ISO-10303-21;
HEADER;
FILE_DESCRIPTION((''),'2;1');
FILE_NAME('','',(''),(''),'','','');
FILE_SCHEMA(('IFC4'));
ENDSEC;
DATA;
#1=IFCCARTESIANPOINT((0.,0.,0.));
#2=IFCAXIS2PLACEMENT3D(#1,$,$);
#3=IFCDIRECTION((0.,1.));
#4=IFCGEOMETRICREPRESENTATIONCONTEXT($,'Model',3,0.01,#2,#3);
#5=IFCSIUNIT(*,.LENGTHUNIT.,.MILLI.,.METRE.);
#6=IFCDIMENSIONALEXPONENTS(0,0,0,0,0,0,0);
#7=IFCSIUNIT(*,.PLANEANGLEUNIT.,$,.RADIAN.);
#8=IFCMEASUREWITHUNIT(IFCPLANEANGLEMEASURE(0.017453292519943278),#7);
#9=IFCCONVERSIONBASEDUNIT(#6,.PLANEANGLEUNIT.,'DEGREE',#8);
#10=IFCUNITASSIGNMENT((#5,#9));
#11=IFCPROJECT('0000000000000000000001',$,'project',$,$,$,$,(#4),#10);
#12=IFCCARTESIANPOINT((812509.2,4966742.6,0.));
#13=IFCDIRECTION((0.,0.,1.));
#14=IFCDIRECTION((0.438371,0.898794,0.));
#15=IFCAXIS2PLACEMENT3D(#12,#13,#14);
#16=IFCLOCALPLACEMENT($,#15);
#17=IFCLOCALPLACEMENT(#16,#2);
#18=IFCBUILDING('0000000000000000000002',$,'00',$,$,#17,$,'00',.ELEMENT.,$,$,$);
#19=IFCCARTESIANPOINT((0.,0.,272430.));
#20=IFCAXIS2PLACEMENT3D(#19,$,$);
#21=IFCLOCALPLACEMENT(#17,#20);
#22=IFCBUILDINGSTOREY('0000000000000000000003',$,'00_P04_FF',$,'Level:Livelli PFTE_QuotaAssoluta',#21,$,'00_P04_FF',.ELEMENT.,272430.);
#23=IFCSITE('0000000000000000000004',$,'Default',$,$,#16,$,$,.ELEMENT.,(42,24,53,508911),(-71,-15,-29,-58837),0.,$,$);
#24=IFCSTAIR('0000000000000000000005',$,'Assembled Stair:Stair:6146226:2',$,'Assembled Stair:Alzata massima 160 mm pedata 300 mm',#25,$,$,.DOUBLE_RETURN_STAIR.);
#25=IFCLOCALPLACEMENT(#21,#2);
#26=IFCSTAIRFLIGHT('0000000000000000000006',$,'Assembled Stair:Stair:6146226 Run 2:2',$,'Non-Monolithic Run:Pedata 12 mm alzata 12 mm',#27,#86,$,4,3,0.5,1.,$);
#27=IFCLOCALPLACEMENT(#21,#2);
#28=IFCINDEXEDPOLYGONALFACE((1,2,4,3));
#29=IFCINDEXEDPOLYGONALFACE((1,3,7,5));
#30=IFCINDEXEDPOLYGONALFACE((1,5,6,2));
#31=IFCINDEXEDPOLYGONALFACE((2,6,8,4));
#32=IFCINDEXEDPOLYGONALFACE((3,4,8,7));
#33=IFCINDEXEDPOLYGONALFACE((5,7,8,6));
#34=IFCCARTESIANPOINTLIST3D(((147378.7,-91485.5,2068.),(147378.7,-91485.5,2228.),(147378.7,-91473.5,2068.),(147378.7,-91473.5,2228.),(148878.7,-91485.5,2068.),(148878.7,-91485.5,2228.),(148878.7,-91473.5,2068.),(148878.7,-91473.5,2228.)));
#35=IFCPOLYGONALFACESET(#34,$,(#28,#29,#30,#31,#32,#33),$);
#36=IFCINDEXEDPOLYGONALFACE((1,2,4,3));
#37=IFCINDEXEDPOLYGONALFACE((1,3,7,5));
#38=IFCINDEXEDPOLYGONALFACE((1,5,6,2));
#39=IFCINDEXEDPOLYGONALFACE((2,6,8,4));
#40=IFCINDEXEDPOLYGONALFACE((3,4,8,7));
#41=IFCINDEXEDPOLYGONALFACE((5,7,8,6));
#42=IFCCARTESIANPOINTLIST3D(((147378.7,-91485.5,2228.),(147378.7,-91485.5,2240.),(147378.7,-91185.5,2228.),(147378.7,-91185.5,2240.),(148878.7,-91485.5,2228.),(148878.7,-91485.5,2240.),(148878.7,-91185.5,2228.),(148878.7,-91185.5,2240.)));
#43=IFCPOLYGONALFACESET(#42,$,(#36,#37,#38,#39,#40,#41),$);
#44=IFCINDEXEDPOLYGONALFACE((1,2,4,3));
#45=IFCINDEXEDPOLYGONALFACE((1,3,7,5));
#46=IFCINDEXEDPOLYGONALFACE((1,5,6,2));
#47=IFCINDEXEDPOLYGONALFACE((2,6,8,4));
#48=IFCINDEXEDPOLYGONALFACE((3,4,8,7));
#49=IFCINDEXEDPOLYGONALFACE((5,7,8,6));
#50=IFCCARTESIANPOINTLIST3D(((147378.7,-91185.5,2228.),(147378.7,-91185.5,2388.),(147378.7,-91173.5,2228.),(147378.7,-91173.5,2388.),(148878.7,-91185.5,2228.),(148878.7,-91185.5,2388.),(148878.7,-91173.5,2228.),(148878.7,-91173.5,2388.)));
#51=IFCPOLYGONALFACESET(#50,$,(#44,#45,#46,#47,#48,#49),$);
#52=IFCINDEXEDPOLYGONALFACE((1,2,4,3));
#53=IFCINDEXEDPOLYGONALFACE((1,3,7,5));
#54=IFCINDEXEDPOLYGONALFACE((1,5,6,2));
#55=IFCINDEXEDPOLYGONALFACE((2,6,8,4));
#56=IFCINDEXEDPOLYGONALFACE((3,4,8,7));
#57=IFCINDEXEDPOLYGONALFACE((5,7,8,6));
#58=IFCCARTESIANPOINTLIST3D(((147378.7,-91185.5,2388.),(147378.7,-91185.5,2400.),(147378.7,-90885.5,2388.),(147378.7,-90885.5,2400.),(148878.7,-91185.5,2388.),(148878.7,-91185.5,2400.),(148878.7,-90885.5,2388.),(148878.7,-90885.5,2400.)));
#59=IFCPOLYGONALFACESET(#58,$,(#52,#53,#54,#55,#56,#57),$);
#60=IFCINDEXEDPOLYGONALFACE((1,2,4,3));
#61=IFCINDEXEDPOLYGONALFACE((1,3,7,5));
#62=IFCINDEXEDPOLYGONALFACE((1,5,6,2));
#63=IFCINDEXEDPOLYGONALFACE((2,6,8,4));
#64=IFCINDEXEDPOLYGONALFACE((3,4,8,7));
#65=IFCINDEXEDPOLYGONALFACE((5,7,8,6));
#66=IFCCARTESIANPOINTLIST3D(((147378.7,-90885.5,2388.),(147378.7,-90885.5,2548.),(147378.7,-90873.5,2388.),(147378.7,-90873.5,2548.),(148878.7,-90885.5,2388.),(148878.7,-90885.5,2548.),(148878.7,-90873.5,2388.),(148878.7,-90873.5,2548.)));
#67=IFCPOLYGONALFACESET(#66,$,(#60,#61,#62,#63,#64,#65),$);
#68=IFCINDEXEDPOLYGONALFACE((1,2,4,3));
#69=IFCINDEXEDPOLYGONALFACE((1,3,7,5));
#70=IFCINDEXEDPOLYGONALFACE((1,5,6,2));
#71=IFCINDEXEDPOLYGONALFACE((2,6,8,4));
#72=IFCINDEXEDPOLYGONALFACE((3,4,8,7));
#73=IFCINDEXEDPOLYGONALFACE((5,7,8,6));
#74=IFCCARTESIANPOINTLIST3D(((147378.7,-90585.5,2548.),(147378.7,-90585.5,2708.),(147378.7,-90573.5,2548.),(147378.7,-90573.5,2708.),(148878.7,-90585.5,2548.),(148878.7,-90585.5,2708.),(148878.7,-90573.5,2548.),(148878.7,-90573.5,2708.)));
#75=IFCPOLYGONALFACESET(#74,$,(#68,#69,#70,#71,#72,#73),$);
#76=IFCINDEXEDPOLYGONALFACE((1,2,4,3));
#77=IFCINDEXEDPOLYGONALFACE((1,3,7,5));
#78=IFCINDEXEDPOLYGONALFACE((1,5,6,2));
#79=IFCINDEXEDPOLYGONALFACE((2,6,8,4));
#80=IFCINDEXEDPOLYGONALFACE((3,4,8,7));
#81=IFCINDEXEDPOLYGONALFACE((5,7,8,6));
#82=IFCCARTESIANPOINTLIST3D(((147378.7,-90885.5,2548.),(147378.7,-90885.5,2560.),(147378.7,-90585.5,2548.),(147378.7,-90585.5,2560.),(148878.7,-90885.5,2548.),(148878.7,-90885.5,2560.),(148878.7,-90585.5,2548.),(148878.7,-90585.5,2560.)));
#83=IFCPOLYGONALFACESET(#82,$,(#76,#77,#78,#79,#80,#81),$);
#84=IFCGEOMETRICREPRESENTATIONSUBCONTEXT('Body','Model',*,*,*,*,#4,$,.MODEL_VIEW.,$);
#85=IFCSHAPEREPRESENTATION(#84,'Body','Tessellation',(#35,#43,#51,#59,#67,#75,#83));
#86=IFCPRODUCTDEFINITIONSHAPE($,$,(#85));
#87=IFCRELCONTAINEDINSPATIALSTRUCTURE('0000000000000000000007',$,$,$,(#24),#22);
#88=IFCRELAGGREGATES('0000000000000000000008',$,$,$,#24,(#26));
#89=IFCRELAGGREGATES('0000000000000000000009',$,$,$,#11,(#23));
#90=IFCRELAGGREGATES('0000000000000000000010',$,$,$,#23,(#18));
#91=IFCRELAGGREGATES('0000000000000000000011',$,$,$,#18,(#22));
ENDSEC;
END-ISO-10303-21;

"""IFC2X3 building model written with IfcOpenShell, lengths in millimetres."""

from ifc_helpers import new_model, entity, si_unit, converted_unit, direction, frame, frame_2d, origin, origin_2d_with_axis, place, context, subcontext, project, spatial, rectangle, extrude, element, aggregate, save


model = new_model("IFC2X3")

# Units and contexts
model_context = context("Model", 3, precision=0.01, world=origin(), true_north=direction((0.0, 1.0)))
body_context = subcontext(model_context, "Body", "Model", "MODEL_VIEW")
ifc_project = project(units=[si_unit("LENGTHUNIT", "METRE", prefix="MILLI"), converted_unit("PLANEANGLEUNIT", "DEGREE", entity("IfcPlaneAngleMeasure", 0.017453292519943278), si_unit("PLANEANGLEUNIT", "RADIAN"), dimensions=[0, 0, 0, 0, 0, 0, 0])], contexts=[model_context])

# Site, building, storey
site_placement = place(None, frame((812509.2, 4966742.6, 0.0), z_axis=(0.0, 0.0, 1.0), x_axis=(0.438371, 0.898794, 0.0)))
site = spatial("IfcSite", under=ifc_project, at=site_placement, Name="Default", CompositionType="ELEMENT", RefLatitude=(42, 24, 53, 508911), RefLongitude=(-71, -15, -29, -58837), RefElevation=0.0)
building_placement = place(site_placement, origin())
building = spatial("IfcBuilding", under=site, at=building_placement, Name="00", LongName="00", CompositionType="ELEMENT")
storey_placement = place(building_placement, frame((0.0, 0.0, 272430.0)))
storey = spatial("IfcBuildingStorey", under=building, at=storey_placement, Name="00_P04_FF", ObjectType="Level:Livelli PFTE_QuotaAssoluta", LongName="00_P04_FF", CompositionType="ELEMENT", Elevation=272430.0)

# Stair
stair_1_placement = place(storey_placement, origin())
stair_1 = element("IfcStair", 1, at=stair_1_placement, inside=storey, Name="Assembled Stair:Stair:6146226:2", ObjectType="Assembled Stair:Alzata massima 160 mm pedata 300 mm", ShapeType="DOUBLE_RETURN_STAIR")

# Stair flight
stair_flight_1_placement = place(stair_1_placement, origin())
stair_flight_1 = element("IfcStairFlight", 2, at=stair_flight_1_placement, Name="Assembled Stair:Stair:6146226 Run 2:2", ObjectType="Non-Monolithic Run:Pedata 12 mm alzata 12 mm", NumberOfRiser=4, NumberOfTreads=3, RiserHeight=0.5, TreadLength=1.0, context=body_context, shape_type="SweptSolid", body=[
    extrude(rectangle(XDim=1500.0, YDim=12.0, at=origin_2d_with_axis()), frame((148128.7, -91479.5, 2068.0), z_axis=(0.0, 0.0, 1.0), x_axis=(-1.0, 0.0, 0.0)), (0.0, 0.0, 1.0), 160.0),
    extrude(rectangle(XDim=300.0, YDim=1500.0, at=frame_2d((0.0, 0.0), x_axis=(1.0, 0.0))), frame((148128.7, -91335.5, 2228.0), z_axis=(0.0, 0.0, 1.0), x_axis=(0.0, -1.0, 0.0)), (0.0, 0.0, 1.0), 12.0),
    extrude(rectangle(XDim=1500.0, YDim=12.0, at=frame_2d((0.0, 0.0), x_axis=(1.0, 0.0))), frame((148128.7, -91179.5, 2228.0), z_axis=(0.0, 0.0, 1.0), x_axis=(-1.0, 0.0, 0.0)), (0.0, 0.0, 1.0), 160.0),
    extrude(rectangle(XDim=300.0, YDim=1500.0, at=origin_2d_with_axis()), frame((148128.7, -91035.5, 2388.0), z_axis=(0.0, 0.0, 1.0), x_axis=(0.0, -1.0, 0.0)), (0.0, 0.0, 1.0), 12.0),
    extrude(rectangle(XDim=1500.0, YDim=12.0, at=frame_2d((0.0, 0.0), x_axis=(1.0, 0.0))), frame((148128.7, -90879.5, 2388.0), z_axis=(0.0, 0.0, 1.0), x_axis=(-1.0, 0.0, 0.0)), (0.0, 0.0, 1.0), 160.0),
    extrude(rectangle(XDim=1500.0, YDim=12.0, at=origin_2d_with_axis()), frame((148128.7, -90579.5, 2548.0), z_axis=(0.0, 0.0, 1.0), x_axis=(-1.0, 0.0, 0.0)), (0.0, 0.0, 1.0), 160.0),
    extrude(rectangle(XDim=300.0, YDim=1500.0, at=origin_2d_with_axis()), frame((148128.7, -90735.5, 2548.0), z_axis=(0.0, 0.0, 1.0), x_axis=(0.0, -1.0, 0.0)), (0.0, 0.0, 1.0), 12.0),
])
aggregate(stair_1, [stair_flight_1])

save(model, "model.ifc")
